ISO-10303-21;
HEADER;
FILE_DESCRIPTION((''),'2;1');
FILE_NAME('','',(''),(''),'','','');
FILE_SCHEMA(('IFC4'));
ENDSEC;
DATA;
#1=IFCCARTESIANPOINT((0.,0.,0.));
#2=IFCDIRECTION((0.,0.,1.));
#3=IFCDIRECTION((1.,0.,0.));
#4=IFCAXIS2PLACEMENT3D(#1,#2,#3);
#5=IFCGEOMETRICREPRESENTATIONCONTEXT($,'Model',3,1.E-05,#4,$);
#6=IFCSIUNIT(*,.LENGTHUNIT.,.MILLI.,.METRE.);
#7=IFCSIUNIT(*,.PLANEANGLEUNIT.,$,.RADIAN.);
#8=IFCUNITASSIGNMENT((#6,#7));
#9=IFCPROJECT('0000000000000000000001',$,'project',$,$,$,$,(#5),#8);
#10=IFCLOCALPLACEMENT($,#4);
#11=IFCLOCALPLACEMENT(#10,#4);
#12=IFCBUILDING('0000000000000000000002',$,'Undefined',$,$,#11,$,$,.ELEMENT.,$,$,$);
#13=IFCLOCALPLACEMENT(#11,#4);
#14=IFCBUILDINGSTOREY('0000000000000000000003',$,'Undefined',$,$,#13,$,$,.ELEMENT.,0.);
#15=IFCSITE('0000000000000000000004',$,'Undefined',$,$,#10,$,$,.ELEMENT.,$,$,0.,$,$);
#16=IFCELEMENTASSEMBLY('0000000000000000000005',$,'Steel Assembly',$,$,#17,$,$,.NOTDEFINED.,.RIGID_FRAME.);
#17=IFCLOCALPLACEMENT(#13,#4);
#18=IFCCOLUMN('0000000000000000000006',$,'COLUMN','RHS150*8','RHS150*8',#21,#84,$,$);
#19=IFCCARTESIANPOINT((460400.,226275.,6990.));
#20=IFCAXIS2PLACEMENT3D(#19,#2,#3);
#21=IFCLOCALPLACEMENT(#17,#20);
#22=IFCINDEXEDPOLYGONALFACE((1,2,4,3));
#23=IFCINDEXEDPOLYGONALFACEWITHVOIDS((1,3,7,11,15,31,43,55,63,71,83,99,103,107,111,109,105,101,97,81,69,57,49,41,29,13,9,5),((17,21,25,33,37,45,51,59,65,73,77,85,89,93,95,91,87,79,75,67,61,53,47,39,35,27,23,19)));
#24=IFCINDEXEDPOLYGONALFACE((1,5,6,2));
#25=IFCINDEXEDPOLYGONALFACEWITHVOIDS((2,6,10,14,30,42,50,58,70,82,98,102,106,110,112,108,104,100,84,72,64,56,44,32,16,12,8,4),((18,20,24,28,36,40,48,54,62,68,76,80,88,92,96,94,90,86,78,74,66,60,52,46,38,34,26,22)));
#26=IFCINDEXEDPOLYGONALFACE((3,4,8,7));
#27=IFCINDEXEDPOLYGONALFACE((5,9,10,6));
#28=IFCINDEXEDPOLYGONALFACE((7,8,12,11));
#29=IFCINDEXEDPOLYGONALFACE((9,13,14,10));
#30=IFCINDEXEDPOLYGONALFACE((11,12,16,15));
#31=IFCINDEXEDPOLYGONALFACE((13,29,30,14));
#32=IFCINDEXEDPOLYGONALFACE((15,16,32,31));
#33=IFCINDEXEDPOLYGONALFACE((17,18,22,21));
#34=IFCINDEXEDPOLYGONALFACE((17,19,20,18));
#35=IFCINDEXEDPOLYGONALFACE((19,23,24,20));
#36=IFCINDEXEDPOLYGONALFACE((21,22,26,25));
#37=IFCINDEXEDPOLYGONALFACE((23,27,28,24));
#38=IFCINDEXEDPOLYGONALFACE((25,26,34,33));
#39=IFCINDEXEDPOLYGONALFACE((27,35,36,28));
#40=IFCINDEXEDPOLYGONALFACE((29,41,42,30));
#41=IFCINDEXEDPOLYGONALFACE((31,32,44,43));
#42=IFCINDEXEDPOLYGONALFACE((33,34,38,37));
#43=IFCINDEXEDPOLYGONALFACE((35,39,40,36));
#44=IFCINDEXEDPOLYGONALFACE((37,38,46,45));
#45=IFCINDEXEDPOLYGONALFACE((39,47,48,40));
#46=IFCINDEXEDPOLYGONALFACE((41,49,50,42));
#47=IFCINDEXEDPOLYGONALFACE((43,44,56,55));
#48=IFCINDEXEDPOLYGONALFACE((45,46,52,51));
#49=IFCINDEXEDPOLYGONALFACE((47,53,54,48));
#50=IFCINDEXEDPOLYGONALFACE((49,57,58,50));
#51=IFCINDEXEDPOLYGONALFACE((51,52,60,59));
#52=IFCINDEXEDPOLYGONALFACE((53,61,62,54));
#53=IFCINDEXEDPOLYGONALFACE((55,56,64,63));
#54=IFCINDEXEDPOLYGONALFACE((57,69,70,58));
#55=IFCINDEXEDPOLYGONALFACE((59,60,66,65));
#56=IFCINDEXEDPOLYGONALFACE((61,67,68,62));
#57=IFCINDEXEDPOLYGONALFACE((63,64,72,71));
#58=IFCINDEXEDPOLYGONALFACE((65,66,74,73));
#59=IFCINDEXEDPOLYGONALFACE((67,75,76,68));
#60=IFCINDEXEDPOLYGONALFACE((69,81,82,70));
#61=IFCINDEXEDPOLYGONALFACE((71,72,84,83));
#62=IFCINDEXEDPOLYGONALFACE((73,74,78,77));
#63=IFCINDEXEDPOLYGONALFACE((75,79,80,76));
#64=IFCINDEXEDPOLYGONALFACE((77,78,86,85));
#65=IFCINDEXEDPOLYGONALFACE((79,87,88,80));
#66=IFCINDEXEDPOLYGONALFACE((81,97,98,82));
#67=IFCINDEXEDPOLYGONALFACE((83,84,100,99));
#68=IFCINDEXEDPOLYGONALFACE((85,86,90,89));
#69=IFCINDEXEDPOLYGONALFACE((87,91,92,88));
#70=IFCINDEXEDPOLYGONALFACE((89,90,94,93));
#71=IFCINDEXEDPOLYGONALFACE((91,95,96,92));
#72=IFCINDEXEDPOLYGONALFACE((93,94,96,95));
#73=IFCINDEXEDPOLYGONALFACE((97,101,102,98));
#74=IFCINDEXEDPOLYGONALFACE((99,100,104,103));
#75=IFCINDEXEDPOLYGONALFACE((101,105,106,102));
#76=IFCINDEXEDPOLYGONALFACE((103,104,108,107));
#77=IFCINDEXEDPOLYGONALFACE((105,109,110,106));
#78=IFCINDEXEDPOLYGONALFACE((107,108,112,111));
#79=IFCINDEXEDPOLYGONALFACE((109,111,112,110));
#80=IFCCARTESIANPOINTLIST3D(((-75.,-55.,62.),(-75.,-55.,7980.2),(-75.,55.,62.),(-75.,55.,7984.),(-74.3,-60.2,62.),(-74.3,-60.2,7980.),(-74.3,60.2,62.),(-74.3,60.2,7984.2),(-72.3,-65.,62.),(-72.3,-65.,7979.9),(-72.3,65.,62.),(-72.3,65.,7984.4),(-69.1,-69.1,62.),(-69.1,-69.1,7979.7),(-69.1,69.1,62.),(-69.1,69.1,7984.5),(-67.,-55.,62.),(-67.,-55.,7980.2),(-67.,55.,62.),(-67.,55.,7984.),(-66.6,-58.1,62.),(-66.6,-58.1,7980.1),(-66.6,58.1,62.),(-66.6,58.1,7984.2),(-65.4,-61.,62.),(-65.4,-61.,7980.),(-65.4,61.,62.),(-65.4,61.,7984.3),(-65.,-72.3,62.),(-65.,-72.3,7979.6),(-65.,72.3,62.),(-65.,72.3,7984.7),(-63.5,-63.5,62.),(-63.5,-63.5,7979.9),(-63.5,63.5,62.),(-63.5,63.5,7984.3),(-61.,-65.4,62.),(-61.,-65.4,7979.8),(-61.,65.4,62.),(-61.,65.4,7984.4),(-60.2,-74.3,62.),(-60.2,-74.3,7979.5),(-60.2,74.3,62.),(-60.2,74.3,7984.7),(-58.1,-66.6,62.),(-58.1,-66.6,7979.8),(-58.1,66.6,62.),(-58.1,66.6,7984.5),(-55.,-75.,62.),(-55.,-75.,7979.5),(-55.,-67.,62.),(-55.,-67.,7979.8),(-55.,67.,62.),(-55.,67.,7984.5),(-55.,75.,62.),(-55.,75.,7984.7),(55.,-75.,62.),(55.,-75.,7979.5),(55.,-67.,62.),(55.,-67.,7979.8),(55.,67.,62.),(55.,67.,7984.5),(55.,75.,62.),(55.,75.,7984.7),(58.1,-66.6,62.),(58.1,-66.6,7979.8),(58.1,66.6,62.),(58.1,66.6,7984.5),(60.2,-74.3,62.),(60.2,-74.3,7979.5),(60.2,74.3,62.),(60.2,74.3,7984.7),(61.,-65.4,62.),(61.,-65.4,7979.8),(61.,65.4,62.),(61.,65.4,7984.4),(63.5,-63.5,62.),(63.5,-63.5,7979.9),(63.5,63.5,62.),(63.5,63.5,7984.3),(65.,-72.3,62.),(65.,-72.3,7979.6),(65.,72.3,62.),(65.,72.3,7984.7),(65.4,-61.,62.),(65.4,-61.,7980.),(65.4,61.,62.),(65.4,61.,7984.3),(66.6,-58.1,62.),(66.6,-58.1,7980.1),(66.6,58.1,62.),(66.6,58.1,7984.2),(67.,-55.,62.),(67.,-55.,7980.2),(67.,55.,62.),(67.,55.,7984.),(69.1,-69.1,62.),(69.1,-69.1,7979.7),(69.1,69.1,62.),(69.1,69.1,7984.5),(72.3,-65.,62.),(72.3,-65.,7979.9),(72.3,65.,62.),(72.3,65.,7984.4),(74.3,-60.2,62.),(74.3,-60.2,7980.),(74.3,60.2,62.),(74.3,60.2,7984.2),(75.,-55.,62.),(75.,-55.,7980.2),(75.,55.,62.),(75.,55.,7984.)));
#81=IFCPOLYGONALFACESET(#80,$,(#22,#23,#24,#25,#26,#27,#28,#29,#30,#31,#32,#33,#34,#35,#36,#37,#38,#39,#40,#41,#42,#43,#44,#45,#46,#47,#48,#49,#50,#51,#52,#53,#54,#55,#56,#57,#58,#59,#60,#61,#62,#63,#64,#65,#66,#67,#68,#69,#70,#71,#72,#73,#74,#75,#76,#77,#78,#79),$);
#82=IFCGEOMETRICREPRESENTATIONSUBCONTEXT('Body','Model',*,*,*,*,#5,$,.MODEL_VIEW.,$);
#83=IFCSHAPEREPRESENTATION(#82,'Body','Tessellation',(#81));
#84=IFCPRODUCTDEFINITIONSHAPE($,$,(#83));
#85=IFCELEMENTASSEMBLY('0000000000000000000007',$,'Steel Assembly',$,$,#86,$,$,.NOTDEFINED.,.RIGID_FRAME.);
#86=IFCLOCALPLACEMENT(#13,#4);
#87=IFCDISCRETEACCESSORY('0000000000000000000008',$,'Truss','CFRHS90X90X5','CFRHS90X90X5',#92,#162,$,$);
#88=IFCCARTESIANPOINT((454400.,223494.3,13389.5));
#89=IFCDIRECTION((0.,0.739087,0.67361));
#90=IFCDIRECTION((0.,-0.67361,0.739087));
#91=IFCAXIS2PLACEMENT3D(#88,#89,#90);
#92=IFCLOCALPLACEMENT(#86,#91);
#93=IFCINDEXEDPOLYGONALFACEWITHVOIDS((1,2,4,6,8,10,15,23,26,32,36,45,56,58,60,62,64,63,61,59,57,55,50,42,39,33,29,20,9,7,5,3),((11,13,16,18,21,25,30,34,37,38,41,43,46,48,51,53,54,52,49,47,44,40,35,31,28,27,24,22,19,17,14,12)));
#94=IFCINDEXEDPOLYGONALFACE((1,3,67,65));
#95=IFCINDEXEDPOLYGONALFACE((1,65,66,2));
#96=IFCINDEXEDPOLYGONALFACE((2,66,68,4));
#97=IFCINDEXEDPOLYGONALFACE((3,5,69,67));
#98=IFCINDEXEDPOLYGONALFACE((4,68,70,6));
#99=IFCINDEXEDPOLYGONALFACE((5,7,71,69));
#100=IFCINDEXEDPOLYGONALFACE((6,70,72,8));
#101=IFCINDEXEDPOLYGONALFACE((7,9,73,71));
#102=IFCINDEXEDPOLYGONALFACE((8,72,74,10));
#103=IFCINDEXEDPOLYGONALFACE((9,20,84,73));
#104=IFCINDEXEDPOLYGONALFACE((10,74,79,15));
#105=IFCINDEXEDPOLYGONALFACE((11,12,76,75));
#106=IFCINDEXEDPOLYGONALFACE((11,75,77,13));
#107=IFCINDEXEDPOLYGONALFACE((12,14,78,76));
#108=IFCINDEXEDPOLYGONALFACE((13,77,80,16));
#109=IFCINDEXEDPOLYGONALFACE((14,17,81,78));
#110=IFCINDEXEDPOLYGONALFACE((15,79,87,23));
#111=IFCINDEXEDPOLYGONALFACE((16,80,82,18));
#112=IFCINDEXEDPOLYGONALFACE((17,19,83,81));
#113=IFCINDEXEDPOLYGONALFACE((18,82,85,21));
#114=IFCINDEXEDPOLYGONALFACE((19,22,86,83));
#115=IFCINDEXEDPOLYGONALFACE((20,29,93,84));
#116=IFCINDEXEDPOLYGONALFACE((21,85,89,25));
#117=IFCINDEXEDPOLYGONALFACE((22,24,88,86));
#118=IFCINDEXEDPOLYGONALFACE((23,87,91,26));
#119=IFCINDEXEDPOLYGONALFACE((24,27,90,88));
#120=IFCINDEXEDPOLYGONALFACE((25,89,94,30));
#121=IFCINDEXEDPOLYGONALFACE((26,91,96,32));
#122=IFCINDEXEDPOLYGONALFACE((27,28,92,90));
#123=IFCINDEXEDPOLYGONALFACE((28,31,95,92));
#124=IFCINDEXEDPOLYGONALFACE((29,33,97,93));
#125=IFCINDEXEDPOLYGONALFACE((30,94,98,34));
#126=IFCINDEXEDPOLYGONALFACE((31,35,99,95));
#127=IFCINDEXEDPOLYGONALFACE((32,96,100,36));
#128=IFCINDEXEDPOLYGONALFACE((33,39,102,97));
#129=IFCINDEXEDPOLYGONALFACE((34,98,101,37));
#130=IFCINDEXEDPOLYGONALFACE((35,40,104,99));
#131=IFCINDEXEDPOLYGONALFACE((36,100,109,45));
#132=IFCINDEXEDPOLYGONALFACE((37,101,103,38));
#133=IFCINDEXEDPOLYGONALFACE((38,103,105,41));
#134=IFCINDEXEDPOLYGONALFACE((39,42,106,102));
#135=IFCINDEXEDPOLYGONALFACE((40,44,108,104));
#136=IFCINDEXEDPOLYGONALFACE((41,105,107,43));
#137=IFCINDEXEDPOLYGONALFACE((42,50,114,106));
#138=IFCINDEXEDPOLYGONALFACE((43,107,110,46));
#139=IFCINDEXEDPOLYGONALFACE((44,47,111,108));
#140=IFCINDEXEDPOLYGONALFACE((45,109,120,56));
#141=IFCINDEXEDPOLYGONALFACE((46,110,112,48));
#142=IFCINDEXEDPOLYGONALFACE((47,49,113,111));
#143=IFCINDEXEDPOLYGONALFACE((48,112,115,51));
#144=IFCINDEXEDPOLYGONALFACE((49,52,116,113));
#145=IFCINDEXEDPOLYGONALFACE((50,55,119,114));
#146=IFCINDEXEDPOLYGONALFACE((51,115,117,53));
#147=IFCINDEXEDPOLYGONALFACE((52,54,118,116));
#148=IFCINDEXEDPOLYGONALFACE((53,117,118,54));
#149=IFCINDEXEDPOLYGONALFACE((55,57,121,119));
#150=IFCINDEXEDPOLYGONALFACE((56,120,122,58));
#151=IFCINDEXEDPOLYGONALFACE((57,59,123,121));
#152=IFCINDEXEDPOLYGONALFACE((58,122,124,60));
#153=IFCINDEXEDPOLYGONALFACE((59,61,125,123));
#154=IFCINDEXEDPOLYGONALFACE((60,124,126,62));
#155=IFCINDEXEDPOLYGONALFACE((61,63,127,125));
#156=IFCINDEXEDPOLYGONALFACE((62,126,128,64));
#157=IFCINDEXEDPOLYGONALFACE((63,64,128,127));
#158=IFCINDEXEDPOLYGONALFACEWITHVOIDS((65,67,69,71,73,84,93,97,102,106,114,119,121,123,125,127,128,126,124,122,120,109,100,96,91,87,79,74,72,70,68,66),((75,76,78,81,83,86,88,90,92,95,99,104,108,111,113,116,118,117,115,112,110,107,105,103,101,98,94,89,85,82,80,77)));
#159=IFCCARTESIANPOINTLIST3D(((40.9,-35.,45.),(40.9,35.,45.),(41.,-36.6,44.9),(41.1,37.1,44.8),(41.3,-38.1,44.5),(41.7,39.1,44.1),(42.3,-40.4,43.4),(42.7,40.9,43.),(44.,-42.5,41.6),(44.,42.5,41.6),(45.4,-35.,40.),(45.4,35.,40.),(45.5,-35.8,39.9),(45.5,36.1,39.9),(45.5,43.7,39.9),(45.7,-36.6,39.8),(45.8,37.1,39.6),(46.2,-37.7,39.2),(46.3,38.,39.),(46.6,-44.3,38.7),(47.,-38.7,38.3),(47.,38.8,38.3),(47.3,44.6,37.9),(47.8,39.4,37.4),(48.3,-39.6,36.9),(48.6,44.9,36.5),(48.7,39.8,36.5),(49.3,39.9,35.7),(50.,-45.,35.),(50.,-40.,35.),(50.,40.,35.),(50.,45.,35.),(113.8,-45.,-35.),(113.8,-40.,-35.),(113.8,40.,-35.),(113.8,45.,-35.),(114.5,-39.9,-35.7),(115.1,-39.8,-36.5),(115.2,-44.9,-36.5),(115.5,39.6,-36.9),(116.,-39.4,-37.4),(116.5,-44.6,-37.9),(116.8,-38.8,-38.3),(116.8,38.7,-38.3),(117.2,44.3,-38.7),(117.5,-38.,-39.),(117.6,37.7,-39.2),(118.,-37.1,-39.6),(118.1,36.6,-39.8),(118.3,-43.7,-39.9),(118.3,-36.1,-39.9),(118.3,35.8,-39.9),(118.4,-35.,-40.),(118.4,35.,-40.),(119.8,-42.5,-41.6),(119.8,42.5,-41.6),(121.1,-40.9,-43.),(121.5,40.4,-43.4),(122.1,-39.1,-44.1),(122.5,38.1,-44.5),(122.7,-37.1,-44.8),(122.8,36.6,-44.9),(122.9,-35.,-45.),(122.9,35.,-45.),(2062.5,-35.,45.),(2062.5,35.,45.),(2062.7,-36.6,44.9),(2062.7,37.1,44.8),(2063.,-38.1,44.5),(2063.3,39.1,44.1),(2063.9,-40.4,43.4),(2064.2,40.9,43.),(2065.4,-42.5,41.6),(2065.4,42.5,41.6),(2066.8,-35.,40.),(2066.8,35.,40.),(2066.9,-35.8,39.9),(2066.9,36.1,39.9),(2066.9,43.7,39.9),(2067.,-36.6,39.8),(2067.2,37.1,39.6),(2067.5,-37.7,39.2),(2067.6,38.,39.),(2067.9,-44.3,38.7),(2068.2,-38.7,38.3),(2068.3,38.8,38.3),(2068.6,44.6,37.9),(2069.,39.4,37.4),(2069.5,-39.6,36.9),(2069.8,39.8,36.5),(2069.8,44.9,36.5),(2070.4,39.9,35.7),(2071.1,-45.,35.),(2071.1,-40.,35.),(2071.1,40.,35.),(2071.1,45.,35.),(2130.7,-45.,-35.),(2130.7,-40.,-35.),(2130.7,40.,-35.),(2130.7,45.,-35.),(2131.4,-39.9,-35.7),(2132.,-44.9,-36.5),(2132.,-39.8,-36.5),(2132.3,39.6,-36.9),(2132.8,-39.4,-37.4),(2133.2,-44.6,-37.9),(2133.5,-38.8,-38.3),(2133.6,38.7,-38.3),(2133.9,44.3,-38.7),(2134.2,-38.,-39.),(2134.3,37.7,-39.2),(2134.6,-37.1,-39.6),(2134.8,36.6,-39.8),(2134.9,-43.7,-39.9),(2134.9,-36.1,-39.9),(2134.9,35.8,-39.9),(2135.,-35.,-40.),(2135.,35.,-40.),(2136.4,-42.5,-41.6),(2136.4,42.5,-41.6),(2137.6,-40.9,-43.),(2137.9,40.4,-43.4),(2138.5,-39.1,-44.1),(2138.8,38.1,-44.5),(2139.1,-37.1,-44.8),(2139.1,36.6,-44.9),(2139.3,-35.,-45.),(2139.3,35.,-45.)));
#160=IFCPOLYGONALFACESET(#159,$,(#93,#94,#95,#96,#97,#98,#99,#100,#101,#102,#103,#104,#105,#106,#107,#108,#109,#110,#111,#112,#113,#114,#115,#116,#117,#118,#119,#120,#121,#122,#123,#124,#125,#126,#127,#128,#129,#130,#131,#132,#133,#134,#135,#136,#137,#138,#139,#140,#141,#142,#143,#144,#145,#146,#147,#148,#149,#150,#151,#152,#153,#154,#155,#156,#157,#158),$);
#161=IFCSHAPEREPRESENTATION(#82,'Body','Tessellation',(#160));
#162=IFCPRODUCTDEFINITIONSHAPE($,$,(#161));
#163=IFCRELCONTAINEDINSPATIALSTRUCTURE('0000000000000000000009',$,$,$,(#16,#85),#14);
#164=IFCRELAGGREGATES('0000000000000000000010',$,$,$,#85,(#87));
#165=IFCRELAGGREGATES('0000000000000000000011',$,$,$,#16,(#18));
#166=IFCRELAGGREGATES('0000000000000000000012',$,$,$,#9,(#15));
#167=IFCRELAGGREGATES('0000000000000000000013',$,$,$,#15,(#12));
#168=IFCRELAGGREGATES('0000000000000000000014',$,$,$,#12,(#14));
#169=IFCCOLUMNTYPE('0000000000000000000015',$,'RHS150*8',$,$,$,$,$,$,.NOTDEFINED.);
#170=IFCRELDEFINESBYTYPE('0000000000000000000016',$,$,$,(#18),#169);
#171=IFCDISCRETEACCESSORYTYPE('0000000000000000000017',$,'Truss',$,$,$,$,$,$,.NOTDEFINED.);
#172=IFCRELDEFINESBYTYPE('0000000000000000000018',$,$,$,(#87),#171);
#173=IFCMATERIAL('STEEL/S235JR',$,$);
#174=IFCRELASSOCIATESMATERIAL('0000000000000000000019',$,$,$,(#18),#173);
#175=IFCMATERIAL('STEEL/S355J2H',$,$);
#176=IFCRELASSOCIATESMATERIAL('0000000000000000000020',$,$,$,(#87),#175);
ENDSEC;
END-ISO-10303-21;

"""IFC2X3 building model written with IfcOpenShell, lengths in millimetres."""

from ifc_helpers import new_model, si_unit, frame, origin_with_axes, origin_2d_with_axis, place, context, subcontext, project, spatial, hollow_rectangle, extrude, clip, halfspace, material, type_object, element, aggregate, save


model = new_model("IFC2X3")

# Units and contexts
model_context = context("Model", 3, precision=1e-05, world=origin_with_axes())
body_context = subcontext(model_context, "Body", "Model", "MODEL_VIEW")
ifc_project = project(units=[si_unit("LENGTHUNIT", "METRE", prefix="MILLI"), si_unit("PLANEANGLEUNIT", "RADIAN")], contexts=[model_context])

# Site, building, storey
site_placement = place(None, origin_with_axes())
site = spatial("IfcSite", under=ifc_project, at=site_placement, Name="Undefined", CompositionType="ELEMENT", RefElevation=0.0)
building_placement = place(site_placement, origin_with_axes())
building = spatial("IfcBuilding", under=site, at=building_placement, Name="Undefined", CompositionType="ELEMENT")
storey_placement = place(building_placement, origin_with_axes())
storey = spatial("IfcBuildingStorey", under=building, at=storey_placement, Name="Undefined", CompositionType="ELEMENT", Elevation=0.0)

# Element assembly, column
ifc_material_1 = material(Name="STEEL/S235JR")
assembly_1_placement = place(storey_placement, origin_with_axes())
assembly_1 = element("IfcElementAssembly", 1, at=assembly_1_placement, inside=storey, Name="Steel Assembly", AssemblyPlace="NOTDEFINED", PredefinedType="RIGID_FRAME")
column_type_1 = type_object("IfcColumnType", Name="RHS150*8", PredefinedType="NOTDEFINED")
column_1_placement = place(assembly_1_placement, frame((460400.0, 226275.0, 6990.0), z_axis=(0.0, 0.0, 1.0), x_axis=(1.0, 0.0, 0.0)))
column_1 = element("IfcColumn", 2, at=column_1_placement, type_object=column_type_1, material=ifc_material_1, Name="COLUMN", Description="RHS150*8", ObjectType="RHS150*8", context=body_context, shape_type="Clipping", body=[
    clip(extrude(hollow_rectangle(XDim=150.0, YDim=150.0, WallThickness=8.0, InnerFilletRadius=12.0, OuterFilletRadius=20.0, at=origin_2d_with_axis()), frame((0.0, 0.0, 7984.8), z_axis=(0.0, 0.0, -1.0), x_axis=(-1.0, 0.0, 0.0)), (0.0, 0.0, 1.0), 7922.8), halfspace(frame((0.0, -89.2, 7979.0), z_axis=(0.0, 0.034899, -0.999391), x_axis=(1.0, 0.0, 0.0)), True)),
])

# Element assembly, discrete accessory
assembly_2_placement = place(storey_placement, origin_with_axes())
assembly_2 = element("IfcElementAssembly", 3, at=assembly_2_placement, inside=storey, Name="Steel Assembly", AssemblyPlace="NOTDEFINED", PredefinedType="RIGID_FRAME")
ifc_material_2 = material(Name="STEEL/S355J2H")
discrete_accessory_type_1 = type_object("IfcDiscreteAccessoryType", Name="Truss")
discrete_accessory_1_placement = place(assembly_2_placement, frame((454400.0, 223494.3, 13389.5), z_axis=(0.0, 0.739087, 0.67361), x_axis=(0.0, -0.67361, 0.739087)))
discrete_accessory_1 = element("IfcDiscreteAccessory", 4, at=discrete_accessory_1_placement, type_object=discrete_accessory_type_1, material=ifc_material_2, Name="Truss", Description="CFRHS90X90X5", ObjectType="CFRHS90X90X5", context=body_context, shape_type="Clipping", body=[
    clip(clip(extrude(hollow_rectangle(XDim=90.0, YDim=90.0, WallThickness=5.0, InnerFilletRadius=5.0, OuterFilletRadius=10.0, at=origin_2d_with_axis()), frame((2184.0, 0.0, 0.0), z_axis=(-1.0, 0.0, 0.0), x_axis=(0.0, -1.0, 0.0)), (0.0, 0.0, 1.0), 2185.2), halfspace(frame((2062.5, 0.0, 45.0), z_axis=(-0.761088, 0.0, -0.648649), x_axis=(0.648649, 0.0, -0.761088)), True)), halfspace(frame((40.9, 0.0, 45.0), z_axis=(-0.739087, 0.0, -0.67361), x_axis=(0.67361, 0.0, -0.739087)), False)),
])

aggregate(assembly_2, [discrete_accessory_1])
aggregate(assembly_1, [column_1])

save(model, "model.ifc")
